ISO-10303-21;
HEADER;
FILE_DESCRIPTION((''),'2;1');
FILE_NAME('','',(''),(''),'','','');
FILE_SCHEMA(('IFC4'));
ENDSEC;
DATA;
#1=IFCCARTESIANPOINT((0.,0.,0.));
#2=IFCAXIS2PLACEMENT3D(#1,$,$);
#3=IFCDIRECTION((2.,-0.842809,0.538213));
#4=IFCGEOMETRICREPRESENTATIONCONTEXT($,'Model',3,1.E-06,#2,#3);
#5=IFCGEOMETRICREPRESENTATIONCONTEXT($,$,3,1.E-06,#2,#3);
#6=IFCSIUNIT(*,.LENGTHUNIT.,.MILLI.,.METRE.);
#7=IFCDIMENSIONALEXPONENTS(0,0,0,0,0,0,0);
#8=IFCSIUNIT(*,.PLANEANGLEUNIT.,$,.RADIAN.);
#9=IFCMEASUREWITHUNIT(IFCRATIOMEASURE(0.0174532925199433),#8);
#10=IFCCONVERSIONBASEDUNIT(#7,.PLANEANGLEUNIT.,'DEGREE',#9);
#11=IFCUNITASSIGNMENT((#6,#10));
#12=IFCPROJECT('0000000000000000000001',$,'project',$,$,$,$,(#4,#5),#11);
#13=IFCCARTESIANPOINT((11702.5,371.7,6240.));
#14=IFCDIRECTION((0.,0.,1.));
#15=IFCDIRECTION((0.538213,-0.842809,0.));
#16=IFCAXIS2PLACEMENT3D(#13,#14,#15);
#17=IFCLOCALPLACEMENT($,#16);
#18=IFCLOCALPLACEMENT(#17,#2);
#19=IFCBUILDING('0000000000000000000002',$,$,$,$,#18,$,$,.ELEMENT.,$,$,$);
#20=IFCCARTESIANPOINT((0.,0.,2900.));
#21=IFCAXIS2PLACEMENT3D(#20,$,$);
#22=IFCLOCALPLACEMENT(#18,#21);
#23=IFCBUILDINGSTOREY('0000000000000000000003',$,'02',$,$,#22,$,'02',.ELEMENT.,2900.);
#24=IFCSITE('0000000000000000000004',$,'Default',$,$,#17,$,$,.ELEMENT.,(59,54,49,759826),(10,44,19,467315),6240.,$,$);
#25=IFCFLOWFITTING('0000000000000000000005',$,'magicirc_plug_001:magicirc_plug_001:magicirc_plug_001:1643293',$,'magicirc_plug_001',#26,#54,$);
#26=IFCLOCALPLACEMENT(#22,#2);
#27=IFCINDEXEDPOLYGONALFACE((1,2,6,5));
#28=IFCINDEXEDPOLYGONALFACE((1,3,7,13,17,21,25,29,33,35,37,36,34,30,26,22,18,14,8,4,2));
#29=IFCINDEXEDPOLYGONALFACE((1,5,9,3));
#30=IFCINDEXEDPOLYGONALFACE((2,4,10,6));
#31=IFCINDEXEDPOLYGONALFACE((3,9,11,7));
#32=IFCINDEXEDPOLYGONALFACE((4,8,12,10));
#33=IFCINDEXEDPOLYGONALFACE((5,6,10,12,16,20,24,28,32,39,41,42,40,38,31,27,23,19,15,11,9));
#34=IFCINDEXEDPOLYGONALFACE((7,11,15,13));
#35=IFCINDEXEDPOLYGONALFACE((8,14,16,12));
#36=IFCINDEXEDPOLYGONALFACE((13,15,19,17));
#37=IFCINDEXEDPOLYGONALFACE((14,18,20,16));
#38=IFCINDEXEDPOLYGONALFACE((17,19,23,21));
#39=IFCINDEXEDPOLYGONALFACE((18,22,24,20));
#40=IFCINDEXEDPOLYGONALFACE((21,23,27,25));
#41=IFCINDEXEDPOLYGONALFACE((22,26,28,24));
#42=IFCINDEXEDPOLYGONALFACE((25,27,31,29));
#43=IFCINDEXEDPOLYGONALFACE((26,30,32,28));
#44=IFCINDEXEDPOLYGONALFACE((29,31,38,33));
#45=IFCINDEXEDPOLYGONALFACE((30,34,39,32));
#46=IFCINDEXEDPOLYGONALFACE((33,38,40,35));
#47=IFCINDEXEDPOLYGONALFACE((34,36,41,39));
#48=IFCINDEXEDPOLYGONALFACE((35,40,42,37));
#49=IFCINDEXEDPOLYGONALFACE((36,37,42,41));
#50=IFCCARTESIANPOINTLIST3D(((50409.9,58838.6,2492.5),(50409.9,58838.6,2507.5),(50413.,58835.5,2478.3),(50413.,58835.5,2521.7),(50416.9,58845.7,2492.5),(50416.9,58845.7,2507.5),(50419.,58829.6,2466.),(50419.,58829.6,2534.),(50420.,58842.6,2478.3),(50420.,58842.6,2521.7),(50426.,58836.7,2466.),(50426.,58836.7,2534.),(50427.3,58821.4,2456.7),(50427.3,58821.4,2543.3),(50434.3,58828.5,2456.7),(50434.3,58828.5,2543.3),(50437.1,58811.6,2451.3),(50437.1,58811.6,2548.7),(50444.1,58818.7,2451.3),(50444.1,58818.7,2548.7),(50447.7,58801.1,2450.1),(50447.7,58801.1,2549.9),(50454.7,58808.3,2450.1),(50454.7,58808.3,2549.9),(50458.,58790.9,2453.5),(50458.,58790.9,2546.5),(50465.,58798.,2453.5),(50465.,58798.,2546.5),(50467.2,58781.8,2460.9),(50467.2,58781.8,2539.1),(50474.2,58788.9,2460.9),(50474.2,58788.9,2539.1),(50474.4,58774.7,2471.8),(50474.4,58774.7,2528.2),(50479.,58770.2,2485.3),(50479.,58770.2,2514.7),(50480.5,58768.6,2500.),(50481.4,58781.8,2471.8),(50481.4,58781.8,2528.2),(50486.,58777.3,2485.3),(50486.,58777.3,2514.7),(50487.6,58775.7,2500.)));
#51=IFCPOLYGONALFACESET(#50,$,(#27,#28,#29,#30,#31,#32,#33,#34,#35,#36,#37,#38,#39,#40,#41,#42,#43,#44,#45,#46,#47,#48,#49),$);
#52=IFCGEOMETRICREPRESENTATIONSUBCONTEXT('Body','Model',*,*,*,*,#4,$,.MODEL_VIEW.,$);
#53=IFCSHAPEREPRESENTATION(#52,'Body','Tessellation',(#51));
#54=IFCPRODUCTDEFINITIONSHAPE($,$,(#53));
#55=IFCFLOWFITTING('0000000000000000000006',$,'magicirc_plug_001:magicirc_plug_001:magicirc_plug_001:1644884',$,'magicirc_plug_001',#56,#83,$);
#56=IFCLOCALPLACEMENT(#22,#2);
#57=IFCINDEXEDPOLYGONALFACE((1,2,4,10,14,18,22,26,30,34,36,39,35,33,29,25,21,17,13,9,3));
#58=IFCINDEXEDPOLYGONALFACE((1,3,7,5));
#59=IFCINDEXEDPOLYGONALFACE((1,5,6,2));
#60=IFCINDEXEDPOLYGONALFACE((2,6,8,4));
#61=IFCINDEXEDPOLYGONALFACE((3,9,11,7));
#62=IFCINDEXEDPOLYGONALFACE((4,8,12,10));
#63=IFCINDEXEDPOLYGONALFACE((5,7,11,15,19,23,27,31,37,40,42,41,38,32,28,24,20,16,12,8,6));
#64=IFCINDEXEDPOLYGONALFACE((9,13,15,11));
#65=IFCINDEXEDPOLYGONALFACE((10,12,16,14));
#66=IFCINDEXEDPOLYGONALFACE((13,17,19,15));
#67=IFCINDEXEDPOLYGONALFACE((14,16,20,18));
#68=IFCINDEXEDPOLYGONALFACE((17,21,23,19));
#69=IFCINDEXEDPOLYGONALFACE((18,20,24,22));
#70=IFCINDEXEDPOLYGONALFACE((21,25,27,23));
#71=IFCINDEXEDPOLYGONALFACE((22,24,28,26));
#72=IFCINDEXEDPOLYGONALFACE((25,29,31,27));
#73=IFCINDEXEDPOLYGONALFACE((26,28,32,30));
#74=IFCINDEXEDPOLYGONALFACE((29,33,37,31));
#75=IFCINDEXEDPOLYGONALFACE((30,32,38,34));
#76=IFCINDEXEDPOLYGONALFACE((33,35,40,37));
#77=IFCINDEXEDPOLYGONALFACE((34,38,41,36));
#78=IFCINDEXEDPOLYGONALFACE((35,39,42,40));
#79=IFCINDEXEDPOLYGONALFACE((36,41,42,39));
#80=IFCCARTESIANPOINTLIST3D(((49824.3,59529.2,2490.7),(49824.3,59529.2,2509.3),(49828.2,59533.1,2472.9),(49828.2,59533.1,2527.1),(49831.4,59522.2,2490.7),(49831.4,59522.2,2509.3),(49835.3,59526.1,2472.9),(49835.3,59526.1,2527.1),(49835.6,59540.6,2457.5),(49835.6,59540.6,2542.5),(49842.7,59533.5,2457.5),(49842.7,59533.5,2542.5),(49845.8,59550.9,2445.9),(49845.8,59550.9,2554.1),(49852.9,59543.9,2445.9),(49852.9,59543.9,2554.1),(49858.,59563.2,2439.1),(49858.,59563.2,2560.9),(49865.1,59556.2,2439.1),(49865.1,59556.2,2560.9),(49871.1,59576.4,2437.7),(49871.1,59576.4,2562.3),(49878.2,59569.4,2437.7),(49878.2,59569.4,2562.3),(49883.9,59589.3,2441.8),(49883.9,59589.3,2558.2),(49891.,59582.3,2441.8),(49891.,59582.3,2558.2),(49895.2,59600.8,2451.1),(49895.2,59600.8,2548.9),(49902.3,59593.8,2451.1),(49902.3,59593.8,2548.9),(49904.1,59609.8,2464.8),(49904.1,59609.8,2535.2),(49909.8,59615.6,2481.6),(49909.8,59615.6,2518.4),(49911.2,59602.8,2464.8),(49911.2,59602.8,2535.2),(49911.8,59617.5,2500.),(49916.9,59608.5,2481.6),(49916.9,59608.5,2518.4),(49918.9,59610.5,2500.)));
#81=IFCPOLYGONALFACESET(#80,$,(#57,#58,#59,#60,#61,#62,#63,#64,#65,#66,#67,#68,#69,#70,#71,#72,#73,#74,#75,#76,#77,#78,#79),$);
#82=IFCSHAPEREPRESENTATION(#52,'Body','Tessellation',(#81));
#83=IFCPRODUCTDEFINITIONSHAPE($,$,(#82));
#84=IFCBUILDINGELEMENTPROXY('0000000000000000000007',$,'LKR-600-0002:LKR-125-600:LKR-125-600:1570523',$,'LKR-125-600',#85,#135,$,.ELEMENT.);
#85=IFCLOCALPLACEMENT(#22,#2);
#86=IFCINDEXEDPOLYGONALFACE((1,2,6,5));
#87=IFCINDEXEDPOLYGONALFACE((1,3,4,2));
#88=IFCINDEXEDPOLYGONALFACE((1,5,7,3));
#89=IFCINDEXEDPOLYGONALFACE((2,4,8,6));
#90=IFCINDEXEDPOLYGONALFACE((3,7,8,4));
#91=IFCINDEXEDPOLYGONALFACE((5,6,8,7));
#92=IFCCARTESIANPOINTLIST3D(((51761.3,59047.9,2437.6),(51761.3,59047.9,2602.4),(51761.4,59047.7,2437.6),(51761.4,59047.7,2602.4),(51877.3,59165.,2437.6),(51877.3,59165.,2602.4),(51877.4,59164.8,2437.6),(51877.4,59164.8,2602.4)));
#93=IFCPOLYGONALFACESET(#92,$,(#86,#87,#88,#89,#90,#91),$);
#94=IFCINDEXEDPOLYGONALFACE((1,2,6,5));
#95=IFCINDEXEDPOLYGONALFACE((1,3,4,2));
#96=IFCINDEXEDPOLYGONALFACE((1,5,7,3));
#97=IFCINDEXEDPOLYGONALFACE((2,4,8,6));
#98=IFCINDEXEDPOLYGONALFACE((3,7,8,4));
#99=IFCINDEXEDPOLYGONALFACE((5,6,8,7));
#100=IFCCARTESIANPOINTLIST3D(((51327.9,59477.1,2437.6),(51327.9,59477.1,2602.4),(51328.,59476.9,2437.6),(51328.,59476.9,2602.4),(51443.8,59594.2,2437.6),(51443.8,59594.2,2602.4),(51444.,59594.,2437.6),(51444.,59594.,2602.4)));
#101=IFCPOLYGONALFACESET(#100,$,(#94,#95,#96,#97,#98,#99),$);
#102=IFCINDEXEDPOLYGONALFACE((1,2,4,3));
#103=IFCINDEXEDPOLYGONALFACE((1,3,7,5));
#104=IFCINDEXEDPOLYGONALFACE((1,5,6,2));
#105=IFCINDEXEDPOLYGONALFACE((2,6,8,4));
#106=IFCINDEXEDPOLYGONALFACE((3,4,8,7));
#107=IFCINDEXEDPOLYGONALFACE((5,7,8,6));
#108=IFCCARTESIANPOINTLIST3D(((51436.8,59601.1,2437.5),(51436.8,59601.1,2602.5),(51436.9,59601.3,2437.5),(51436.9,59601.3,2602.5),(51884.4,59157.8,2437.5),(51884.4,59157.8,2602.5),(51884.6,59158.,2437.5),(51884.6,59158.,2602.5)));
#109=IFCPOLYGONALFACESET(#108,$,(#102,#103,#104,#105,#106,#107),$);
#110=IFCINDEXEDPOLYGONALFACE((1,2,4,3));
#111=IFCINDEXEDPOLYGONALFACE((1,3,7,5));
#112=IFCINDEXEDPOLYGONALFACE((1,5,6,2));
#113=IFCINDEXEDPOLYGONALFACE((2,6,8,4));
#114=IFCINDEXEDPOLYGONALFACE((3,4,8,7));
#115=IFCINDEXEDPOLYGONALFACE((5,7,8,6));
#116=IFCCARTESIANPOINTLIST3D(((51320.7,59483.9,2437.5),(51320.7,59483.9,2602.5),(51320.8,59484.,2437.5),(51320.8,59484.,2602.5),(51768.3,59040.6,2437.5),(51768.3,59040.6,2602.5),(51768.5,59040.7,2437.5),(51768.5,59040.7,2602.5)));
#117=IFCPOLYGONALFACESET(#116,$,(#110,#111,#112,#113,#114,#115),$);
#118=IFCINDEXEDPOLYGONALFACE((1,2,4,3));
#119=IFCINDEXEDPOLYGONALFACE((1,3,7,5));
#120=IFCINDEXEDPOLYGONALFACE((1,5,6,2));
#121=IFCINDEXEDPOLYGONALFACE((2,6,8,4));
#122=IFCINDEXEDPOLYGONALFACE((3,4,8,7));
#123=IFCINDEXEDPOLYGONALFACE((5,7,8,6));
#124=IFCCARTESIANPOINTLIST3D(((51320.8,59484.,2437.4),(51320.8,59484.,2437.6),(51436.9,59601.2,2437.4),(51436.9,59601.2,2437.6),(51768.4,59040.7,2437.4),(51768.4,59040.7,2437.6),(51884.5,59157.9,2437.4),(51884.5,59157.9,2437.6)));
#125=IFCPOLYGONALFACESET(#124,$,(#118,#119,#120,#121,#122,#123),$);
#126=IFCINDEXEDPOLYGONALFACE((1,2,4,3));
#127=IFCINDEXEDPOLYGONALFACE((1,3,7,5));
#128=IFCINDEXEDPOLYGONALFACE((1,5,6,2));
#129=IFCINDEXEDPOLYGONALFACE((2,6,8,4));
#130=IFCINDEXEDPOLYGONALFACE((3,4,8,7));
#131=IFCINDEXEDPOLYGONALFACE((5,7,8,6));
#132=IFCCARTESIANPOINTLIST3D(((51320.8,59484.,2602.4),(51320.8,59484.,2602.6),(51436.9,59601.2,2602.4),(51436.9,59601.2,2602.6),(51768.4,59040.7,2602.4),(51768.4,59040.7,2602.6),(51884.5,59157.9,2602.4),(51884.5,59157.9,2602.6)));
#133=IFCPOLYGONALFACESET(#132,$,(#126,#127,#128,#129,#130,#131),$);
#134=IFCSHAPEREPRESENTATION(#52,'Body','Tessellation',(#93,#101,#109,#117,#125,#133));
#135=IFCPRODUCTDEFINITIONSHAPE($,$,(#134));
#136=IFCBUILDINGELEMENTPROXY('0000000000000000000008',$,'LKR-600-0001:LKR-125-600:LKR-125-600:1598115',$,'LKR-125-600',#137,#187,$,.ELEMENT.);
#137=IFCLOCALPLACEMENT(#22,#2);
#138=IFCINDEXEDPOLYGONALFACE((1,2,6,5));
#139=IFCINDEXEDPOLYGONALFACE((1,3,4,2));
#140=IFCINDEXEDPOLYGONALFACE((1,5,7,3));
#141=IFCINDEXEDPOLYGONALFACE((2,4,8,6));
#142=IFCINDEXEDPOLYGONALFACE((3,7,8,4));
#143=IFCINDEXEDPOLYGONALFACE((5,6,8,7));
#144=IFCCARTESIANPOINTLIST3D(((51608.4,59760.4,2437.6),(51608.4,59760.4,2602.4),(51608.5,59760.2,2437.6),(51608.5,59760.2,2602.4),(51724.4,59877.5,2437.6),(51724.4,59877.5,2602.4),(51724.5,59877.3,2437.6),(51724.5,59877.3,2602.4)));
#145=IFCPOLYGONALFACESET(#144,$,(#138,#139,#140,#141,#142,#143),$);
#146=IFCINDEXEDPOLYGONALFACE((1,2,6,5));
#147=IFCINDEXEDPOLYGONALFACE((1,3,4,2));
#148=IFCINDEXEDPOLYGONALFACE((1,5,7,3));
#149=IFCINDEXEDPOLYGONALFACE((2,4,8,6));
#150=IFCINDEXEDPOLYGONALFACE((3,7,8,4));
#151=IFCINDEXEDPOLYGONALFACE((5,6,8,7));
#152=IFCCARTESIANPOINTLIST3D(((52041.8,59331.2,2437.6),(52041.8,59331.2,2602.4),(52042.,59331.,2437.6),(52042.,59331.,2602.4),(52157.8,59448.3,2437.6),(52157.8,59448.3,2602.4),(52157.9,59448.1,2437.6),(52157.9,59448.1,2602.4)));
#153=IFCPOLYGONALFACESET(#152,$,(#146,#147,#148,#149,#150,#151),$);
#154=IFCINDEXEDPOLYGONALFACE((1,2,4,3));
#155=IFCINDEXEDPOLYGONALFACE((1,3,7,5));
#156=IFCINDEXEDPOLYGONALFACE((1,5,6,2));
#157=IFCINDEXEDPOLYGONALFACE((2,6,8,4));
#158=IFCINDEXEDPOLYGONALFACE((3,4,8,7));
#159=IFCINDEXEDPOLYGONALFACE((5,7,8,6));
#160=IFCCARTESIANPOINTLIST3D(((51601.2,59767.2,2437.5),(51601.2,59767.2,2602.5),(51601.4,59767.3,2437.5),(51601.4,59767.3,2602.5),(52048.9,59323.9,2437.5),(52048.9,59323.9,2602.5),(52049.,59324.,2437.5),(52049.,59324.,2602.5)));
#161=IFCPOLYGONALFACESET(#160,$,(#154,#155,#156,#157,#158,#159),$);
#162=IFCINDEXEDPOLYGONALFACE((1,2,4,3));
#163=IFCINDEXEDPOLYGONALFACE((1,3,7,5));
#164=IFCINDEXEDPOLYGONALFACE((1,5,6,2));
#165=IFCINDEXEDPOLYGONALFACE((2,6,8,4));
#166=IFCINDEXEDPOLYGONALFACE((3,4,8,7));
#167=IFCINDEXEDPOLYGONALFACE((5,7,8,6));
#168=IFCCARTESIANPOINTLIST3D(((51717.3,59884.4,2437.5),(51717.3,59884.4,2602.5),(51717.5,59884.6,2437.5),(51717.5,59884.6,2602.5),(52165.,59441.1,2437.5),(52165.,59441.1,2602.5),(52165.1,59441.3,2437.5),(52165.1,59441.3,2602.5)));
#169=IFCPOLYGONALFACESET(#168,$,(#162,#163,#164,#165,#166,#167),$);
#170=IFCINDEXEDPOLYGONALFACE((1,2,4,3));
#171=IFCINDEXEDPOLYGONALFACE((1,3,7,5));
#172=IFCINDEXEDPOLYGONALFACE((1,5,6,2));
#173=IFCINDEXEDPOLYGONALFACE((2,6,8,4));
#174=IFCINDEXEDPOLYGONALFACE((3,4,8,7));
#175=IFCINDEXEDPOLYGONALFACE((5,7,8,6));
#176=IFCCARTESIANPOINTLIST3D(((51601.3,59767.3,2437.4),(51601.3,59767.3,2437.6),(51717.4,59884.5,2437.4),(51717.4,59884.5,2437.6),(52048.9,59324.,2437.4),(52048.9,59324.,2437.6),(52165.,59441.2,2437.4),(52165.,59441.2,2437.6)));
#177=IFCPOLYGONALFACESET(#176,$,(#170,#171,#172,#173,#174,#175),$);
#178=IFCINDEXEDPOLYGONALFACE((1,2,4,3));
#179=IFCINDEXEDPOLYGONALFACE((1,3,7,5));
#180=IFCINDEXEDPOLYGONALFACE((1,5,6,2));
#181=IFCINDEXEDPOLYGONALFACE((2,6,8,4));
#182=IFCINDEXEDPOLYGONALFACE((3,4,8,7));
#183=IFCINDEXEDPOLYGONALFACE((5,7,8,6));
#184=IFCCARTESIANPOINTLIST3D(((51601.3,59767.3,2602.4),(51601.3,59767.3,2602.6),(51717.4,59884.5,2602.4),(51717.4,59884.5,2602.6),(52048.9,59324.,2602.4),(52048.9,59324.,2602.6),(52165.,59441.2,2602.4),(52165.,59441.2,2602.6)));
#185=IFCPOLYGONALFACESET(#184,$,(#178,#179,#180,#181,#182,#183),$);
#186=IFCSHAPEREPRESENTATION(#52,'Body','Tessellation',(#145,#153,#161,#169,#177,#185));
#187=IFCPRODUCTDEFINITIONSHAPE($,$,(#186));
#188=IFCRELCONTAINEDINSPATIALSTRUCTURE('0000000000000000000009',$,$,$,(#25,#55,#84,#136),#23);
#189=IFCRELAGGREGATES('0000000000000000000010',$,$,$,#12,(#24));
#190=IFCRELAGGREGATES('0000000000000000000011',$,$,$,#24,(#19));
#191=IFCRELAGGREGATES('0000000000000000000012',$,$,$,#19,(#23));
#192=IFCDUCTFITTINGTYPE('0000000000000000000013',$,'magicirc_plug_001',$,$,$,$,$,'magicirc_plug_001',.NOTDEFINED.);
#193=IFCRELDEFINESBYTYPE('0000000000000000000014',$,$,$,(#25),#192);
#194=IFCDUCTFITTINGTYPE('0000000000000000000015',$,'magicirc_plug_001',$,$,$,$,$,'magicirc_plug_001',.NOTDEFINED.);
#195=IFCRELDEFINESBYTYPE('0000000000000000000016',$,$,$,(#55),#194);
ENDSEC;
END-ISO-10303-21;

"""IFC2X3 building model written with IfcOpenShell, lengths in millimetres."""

from ifc_helpers import new_model, entity, si_unit, converted_unit, direction, frame, frame_2d, origin, place, context, subcontext, project, spatial, rectangle, circle, extrude, source, transform, mapped, type_object, type_shapes, element, save


model = new_model("IFC2X3")

# Units and contexts
model_context = context("Model", 3, precision=1e-06, world=origin(), true_north=direction((2.0, -0.842809, 0.538213)))
context_of_model = context(None, 3, precision=1e-06, world=origin(), true_north=direction((2.0, -0.842809, 0.538213)))
body_context = subcontext(model_context, "Body", "Model", "MODEL_VIEW")
ifc_project = project(units=[si_unit("LENGTHUNIT", "METRE", prefix="MILLI"), converted_unit("PLANEANGLEUNIT", "DEGREE", entity("IfcRatioMeasure", 0.0174532925199433), si_unit("PLANEANGLEUNIT", "RADIAN"), dimensions=[0, 0, 0, 0, 0, 0, 0])], contexts=[model_context, context_of_model])

# Site, building, storey
site_placement = place(None, frame((11702.5, 371.7, 6240.0), z_axis=(0.0, 0.0, 1.0), x_axis=(0.538213, -0.842809, 0.0)))
site = spatial("IfcSite", under=ifc_project, at=site_placement, Name="Default", CompositionType="ELEMENT", RefLatitude=(59, 54, 49, 759826), RefLongitude=(10, 44, 19, 467315), RefElevation=6240.0)
building_placement = place(site_placement, origin())
building = spatial("IfcBuilding", under=site, at=building_placement, CompositionType="ELEMENT")
storey_placement = place(building_placement, frame((0.0, 0.0, 2900.0)))
storey = spatial("IfcBuildingStorey", under=building, at=storey_placement, Name="02", LongName="02", CompositionType="ELEMENT", Elevation=2900.0)

# Flow fittings
duct_fitting_type_1 = type_object("IfcDuctFittingType", Name="magicirc_plug_001", ElementType="magicirc_plug_001", PredefinedType="NOTDEFINED")
shared_shape_1 = source(origin(), body_context, "Body", "SweptSolid", [
    extrude(circle(Radius=50.0, at=frame_2d((0.0, 0.0), x_axis=(1.0, 0.0))), frame((0.0, 0.0, 0.0), z_axis=(1.0, 0.0, 0.0), x_axis=(0.0, 1.0, 0.0)), (0.0, 0.0, 1.0), 10.0),
])
type_shapes(duct_fitting_type_1, [shared_shape_1])
flow_fitting_1_placement = place(storey_placement, frame((50452.1, 58810.9, 2500.0), z_axis=(0.0, 0.0, 1.0), x_axis=(-0.703643, -0.710554, 0.0)))
element("IfcFlowFitting", 1, at=flow_fitting_1_placement, inside=storey, type_object=duct_fitting_type_1, Name="magicirc_plug_001:magicirc_plug_001:magicirc_plug_001:1643293", ObjectType="magicirc_plug_001", context=body_context, shape_type="MappedRepresentation", body=[
    mapped(shared_shape_1, transform((0.0, 0.0, 0.0), scale=1.0)),
])
duct_fitting_type_2 = type_object("IfcDuctFittingType", Name="magicirc_plug_001", ElementType="magicirc_plug_001", PredefinedType="NOTDEFINED")
shared_shape_2 = source(origin(), body_context, "Body", "SweptSolid", [
    extrude(circle(Radius=62.5, at=frame_2d((0.0, 0.0), x_axis=(1.0, 0.0))), frame((0.0, 0.0, 0.0), z_axis=(1.0, 0.0, 0.0), x_axis=(0.0, 1.0, 0.0)), (0.0, 0.0, 1.0), 10.0),
])
type_shapes(duct_fitting_type_2, [shared_shape_2])
flow_fitting_2_placement = place(storey_placement, frame((49867.8, 59573.1, 2500.0), z_axis=(0.0, 0.0, 1.0), x_axis=(0.710554, -0.703643, 0.0)))
element("IfcFlowFitting", 2, at=flow_fitting_2_placement, inside=storey, type_object=duct_fitting_type_2, Name="magicirc_plug_001:magicirc_plug_001:magicirc_plug_001:1644884", ObjectType="magicirc_plug_001", context=body_context, shape_type="MappedRepresentation", body=[
    mapped(shared_shape_2, transform((0.0, 0.0, 0.0), scale=1.0)),
])

# Building element proxies
shared_shape_3 = source(origin(), body_context, "Body", "SweptSolid", [
    extrude(rectangle(XDim=0.2, YDim=164.8, at=frame_2d((0.0, 0.0), x_axis=(1.0, 0.0))), frame((305.0, 0.0, -82.4)), (0.0, 0.0, 1.0), 164.8),
    extrude(rectangle(XDim=0.2, YDim=164.8, at=frame_2d((0.0, 0.0), x_axis=(1.0, 0.0))), frame((-305.0, 0.0, -82.4)), (0.0, 0.0, 1.0), 164.8),
    extrude(rectangle(XDim=0.2, YDim=630.0, at=frame_2d((0.0, 0.0), x_axis=(1.0, 0.0))), frame((0.0, 82.5, -82.5), z_axis=(0.0, 0.0, 1.0), x_axis=(0.0, 1.0, 0.0)), (0.0, 0.0, 1.0), 165.0),
    extrude(rectangle(XDim=0.2, YDim=630.0, at=frame_2d((0.0, 0.0), x_axis=(1.0, 0.0))), frame((0.0, -82.5, -82.5), z_axis=(0.0, 0.0, 1.0), x_axis=(0.0, 1.0, 0.0)), (0.0, 0.0, 1.0), 165.0),
    extrude(rectangle(XDim=165.0, YDim=630.0, at=frame_2d((0.0, 0.0), x_axis=(1.0, 0.0))), frame((0.0, 0.0, -82.6), z_axis=(0.0, 0.0, 1.0), x_axis=(0.0, -1.0, 0.0)), (0.0, 0.0, 1.0), 0.2),
    extrude(rectangle(XDim=165.0, YDim=630.0, at=frame_2d((0.0, 0.0), x_axis=(1.0, 0.0))), frame((0.0, 0.0, 82.4), z_axis=(0.0, 0.0, 1.0), x_axis=(0.0, -1.0, 0.0)), (0.0, 0.0, 1.0), 0.2),
])
proxy_1_placement = place(storey_placement, frame((51602.6, 59320.9, 2520.0), z_axis=(0.0, 0.0, 1.0), x_axis=(0.710554, -0.703643, 0.0)))
element("IfcBuildingElementProxy", 3, at=proxy_1_placement, inside=storey, Name="LKR-600-0002:LKR-125-600:LKR-125-600:1570523", ObjectType="LKR-125-600", CompositionType="ELEMENT", context=body_context, shape_type="MappedRepresentation", body=[
    mapped(shared_shape_3, transform((0.0, 0.0, 0.0), scale=1.0)),
])
shared_shape_4 = source(origin(), body_context, "Body", "SweptSolid", [
    extrude(rectangle(XDim=0.2, YDim=164.8, at=frame_2d((0.0, 0.0), x_axis=(1.0, 0.0))), frame((305.0, 0.0, -82.4)), (0.0, 0.0, 1.0), 164.8),
    extrude(rectangle(XDim=0.2, YDim=164.8, at=frame_2d((0.0, 0.0), x_axis=(1.0, 0.0))), frame((-305.0, 0.0, -82.4)), (0.0, 0.0, 1.0), 164.8),
    extrude(rectangle(XDim=0.2, YDim=630.0, at=frame_2d((0.0, 0.0), x_axis=(1.0, 0.0))), frame((0.0, 82.5, -82.5), z_axis=(0.0, 0.0, 1.0), x_axis=(0.0, 1.0, 0.0)), (0.0, 0.0, 1.0), 165.0),
    extrude(rectangle(XDim=0.2, YDim=630.0, at=frame_2d((0.0, 0.0), x_axis=(1.0, 0.0))), frame((0.0, -82.5, -82.5), z_axis=(0.0, 0.0, 1.0), x_axis=(0.0, 1.0, 0.0)), (0.0, 0.0, 1.0), 165.0),
    extrude(rectangle(XDim=165.0, YDim=630.0, at=frame_2d((0.0, 0.0), x_axis=(1.0, 0.0))), frame((0.0, 0.0, -82.6), z_axis=(0.0, 0.0, 1.0), x_axis=(0.0, -1.0, 0.0)), (0.0, 0.0, 1.0), 0.2),
    extrude(rectangle(XDim=165.0, YDim=630.0, at=frame_2d((0.0, 0.0), x_axis=(1.0, 0.0))), frame((0.0, 0.0, 82.4), z_axis=(0.0, 0.0, 1.0), x_axis=(0.0, -1.0, 0.0)), (0.0, 0.0, 1.0), 0.2),
])
proxy_2_placement = place(storey_placement, frame((51883.2, 59604.2, 2520.0), z_axis=(0.0, 0.0, 1.0), x_axis=(-0.710554, 0.703643, 0.0)))
element("IfcBuildingElementProxy", 4, at=proxy_2_placement, inside=storey, Name="LKR-600-0001:LKR-125-600:LKR-125-600:1598115", ObjectType="LKR-125-600", CompositionType="ELEMENT", context=body_context, shape_type="MappedRepresentation", body=[
    mapped(shared_shape_4, transform((0.0, 0.0, 0.0), scale=1.0)),
])

save(model, "model.ifc")
